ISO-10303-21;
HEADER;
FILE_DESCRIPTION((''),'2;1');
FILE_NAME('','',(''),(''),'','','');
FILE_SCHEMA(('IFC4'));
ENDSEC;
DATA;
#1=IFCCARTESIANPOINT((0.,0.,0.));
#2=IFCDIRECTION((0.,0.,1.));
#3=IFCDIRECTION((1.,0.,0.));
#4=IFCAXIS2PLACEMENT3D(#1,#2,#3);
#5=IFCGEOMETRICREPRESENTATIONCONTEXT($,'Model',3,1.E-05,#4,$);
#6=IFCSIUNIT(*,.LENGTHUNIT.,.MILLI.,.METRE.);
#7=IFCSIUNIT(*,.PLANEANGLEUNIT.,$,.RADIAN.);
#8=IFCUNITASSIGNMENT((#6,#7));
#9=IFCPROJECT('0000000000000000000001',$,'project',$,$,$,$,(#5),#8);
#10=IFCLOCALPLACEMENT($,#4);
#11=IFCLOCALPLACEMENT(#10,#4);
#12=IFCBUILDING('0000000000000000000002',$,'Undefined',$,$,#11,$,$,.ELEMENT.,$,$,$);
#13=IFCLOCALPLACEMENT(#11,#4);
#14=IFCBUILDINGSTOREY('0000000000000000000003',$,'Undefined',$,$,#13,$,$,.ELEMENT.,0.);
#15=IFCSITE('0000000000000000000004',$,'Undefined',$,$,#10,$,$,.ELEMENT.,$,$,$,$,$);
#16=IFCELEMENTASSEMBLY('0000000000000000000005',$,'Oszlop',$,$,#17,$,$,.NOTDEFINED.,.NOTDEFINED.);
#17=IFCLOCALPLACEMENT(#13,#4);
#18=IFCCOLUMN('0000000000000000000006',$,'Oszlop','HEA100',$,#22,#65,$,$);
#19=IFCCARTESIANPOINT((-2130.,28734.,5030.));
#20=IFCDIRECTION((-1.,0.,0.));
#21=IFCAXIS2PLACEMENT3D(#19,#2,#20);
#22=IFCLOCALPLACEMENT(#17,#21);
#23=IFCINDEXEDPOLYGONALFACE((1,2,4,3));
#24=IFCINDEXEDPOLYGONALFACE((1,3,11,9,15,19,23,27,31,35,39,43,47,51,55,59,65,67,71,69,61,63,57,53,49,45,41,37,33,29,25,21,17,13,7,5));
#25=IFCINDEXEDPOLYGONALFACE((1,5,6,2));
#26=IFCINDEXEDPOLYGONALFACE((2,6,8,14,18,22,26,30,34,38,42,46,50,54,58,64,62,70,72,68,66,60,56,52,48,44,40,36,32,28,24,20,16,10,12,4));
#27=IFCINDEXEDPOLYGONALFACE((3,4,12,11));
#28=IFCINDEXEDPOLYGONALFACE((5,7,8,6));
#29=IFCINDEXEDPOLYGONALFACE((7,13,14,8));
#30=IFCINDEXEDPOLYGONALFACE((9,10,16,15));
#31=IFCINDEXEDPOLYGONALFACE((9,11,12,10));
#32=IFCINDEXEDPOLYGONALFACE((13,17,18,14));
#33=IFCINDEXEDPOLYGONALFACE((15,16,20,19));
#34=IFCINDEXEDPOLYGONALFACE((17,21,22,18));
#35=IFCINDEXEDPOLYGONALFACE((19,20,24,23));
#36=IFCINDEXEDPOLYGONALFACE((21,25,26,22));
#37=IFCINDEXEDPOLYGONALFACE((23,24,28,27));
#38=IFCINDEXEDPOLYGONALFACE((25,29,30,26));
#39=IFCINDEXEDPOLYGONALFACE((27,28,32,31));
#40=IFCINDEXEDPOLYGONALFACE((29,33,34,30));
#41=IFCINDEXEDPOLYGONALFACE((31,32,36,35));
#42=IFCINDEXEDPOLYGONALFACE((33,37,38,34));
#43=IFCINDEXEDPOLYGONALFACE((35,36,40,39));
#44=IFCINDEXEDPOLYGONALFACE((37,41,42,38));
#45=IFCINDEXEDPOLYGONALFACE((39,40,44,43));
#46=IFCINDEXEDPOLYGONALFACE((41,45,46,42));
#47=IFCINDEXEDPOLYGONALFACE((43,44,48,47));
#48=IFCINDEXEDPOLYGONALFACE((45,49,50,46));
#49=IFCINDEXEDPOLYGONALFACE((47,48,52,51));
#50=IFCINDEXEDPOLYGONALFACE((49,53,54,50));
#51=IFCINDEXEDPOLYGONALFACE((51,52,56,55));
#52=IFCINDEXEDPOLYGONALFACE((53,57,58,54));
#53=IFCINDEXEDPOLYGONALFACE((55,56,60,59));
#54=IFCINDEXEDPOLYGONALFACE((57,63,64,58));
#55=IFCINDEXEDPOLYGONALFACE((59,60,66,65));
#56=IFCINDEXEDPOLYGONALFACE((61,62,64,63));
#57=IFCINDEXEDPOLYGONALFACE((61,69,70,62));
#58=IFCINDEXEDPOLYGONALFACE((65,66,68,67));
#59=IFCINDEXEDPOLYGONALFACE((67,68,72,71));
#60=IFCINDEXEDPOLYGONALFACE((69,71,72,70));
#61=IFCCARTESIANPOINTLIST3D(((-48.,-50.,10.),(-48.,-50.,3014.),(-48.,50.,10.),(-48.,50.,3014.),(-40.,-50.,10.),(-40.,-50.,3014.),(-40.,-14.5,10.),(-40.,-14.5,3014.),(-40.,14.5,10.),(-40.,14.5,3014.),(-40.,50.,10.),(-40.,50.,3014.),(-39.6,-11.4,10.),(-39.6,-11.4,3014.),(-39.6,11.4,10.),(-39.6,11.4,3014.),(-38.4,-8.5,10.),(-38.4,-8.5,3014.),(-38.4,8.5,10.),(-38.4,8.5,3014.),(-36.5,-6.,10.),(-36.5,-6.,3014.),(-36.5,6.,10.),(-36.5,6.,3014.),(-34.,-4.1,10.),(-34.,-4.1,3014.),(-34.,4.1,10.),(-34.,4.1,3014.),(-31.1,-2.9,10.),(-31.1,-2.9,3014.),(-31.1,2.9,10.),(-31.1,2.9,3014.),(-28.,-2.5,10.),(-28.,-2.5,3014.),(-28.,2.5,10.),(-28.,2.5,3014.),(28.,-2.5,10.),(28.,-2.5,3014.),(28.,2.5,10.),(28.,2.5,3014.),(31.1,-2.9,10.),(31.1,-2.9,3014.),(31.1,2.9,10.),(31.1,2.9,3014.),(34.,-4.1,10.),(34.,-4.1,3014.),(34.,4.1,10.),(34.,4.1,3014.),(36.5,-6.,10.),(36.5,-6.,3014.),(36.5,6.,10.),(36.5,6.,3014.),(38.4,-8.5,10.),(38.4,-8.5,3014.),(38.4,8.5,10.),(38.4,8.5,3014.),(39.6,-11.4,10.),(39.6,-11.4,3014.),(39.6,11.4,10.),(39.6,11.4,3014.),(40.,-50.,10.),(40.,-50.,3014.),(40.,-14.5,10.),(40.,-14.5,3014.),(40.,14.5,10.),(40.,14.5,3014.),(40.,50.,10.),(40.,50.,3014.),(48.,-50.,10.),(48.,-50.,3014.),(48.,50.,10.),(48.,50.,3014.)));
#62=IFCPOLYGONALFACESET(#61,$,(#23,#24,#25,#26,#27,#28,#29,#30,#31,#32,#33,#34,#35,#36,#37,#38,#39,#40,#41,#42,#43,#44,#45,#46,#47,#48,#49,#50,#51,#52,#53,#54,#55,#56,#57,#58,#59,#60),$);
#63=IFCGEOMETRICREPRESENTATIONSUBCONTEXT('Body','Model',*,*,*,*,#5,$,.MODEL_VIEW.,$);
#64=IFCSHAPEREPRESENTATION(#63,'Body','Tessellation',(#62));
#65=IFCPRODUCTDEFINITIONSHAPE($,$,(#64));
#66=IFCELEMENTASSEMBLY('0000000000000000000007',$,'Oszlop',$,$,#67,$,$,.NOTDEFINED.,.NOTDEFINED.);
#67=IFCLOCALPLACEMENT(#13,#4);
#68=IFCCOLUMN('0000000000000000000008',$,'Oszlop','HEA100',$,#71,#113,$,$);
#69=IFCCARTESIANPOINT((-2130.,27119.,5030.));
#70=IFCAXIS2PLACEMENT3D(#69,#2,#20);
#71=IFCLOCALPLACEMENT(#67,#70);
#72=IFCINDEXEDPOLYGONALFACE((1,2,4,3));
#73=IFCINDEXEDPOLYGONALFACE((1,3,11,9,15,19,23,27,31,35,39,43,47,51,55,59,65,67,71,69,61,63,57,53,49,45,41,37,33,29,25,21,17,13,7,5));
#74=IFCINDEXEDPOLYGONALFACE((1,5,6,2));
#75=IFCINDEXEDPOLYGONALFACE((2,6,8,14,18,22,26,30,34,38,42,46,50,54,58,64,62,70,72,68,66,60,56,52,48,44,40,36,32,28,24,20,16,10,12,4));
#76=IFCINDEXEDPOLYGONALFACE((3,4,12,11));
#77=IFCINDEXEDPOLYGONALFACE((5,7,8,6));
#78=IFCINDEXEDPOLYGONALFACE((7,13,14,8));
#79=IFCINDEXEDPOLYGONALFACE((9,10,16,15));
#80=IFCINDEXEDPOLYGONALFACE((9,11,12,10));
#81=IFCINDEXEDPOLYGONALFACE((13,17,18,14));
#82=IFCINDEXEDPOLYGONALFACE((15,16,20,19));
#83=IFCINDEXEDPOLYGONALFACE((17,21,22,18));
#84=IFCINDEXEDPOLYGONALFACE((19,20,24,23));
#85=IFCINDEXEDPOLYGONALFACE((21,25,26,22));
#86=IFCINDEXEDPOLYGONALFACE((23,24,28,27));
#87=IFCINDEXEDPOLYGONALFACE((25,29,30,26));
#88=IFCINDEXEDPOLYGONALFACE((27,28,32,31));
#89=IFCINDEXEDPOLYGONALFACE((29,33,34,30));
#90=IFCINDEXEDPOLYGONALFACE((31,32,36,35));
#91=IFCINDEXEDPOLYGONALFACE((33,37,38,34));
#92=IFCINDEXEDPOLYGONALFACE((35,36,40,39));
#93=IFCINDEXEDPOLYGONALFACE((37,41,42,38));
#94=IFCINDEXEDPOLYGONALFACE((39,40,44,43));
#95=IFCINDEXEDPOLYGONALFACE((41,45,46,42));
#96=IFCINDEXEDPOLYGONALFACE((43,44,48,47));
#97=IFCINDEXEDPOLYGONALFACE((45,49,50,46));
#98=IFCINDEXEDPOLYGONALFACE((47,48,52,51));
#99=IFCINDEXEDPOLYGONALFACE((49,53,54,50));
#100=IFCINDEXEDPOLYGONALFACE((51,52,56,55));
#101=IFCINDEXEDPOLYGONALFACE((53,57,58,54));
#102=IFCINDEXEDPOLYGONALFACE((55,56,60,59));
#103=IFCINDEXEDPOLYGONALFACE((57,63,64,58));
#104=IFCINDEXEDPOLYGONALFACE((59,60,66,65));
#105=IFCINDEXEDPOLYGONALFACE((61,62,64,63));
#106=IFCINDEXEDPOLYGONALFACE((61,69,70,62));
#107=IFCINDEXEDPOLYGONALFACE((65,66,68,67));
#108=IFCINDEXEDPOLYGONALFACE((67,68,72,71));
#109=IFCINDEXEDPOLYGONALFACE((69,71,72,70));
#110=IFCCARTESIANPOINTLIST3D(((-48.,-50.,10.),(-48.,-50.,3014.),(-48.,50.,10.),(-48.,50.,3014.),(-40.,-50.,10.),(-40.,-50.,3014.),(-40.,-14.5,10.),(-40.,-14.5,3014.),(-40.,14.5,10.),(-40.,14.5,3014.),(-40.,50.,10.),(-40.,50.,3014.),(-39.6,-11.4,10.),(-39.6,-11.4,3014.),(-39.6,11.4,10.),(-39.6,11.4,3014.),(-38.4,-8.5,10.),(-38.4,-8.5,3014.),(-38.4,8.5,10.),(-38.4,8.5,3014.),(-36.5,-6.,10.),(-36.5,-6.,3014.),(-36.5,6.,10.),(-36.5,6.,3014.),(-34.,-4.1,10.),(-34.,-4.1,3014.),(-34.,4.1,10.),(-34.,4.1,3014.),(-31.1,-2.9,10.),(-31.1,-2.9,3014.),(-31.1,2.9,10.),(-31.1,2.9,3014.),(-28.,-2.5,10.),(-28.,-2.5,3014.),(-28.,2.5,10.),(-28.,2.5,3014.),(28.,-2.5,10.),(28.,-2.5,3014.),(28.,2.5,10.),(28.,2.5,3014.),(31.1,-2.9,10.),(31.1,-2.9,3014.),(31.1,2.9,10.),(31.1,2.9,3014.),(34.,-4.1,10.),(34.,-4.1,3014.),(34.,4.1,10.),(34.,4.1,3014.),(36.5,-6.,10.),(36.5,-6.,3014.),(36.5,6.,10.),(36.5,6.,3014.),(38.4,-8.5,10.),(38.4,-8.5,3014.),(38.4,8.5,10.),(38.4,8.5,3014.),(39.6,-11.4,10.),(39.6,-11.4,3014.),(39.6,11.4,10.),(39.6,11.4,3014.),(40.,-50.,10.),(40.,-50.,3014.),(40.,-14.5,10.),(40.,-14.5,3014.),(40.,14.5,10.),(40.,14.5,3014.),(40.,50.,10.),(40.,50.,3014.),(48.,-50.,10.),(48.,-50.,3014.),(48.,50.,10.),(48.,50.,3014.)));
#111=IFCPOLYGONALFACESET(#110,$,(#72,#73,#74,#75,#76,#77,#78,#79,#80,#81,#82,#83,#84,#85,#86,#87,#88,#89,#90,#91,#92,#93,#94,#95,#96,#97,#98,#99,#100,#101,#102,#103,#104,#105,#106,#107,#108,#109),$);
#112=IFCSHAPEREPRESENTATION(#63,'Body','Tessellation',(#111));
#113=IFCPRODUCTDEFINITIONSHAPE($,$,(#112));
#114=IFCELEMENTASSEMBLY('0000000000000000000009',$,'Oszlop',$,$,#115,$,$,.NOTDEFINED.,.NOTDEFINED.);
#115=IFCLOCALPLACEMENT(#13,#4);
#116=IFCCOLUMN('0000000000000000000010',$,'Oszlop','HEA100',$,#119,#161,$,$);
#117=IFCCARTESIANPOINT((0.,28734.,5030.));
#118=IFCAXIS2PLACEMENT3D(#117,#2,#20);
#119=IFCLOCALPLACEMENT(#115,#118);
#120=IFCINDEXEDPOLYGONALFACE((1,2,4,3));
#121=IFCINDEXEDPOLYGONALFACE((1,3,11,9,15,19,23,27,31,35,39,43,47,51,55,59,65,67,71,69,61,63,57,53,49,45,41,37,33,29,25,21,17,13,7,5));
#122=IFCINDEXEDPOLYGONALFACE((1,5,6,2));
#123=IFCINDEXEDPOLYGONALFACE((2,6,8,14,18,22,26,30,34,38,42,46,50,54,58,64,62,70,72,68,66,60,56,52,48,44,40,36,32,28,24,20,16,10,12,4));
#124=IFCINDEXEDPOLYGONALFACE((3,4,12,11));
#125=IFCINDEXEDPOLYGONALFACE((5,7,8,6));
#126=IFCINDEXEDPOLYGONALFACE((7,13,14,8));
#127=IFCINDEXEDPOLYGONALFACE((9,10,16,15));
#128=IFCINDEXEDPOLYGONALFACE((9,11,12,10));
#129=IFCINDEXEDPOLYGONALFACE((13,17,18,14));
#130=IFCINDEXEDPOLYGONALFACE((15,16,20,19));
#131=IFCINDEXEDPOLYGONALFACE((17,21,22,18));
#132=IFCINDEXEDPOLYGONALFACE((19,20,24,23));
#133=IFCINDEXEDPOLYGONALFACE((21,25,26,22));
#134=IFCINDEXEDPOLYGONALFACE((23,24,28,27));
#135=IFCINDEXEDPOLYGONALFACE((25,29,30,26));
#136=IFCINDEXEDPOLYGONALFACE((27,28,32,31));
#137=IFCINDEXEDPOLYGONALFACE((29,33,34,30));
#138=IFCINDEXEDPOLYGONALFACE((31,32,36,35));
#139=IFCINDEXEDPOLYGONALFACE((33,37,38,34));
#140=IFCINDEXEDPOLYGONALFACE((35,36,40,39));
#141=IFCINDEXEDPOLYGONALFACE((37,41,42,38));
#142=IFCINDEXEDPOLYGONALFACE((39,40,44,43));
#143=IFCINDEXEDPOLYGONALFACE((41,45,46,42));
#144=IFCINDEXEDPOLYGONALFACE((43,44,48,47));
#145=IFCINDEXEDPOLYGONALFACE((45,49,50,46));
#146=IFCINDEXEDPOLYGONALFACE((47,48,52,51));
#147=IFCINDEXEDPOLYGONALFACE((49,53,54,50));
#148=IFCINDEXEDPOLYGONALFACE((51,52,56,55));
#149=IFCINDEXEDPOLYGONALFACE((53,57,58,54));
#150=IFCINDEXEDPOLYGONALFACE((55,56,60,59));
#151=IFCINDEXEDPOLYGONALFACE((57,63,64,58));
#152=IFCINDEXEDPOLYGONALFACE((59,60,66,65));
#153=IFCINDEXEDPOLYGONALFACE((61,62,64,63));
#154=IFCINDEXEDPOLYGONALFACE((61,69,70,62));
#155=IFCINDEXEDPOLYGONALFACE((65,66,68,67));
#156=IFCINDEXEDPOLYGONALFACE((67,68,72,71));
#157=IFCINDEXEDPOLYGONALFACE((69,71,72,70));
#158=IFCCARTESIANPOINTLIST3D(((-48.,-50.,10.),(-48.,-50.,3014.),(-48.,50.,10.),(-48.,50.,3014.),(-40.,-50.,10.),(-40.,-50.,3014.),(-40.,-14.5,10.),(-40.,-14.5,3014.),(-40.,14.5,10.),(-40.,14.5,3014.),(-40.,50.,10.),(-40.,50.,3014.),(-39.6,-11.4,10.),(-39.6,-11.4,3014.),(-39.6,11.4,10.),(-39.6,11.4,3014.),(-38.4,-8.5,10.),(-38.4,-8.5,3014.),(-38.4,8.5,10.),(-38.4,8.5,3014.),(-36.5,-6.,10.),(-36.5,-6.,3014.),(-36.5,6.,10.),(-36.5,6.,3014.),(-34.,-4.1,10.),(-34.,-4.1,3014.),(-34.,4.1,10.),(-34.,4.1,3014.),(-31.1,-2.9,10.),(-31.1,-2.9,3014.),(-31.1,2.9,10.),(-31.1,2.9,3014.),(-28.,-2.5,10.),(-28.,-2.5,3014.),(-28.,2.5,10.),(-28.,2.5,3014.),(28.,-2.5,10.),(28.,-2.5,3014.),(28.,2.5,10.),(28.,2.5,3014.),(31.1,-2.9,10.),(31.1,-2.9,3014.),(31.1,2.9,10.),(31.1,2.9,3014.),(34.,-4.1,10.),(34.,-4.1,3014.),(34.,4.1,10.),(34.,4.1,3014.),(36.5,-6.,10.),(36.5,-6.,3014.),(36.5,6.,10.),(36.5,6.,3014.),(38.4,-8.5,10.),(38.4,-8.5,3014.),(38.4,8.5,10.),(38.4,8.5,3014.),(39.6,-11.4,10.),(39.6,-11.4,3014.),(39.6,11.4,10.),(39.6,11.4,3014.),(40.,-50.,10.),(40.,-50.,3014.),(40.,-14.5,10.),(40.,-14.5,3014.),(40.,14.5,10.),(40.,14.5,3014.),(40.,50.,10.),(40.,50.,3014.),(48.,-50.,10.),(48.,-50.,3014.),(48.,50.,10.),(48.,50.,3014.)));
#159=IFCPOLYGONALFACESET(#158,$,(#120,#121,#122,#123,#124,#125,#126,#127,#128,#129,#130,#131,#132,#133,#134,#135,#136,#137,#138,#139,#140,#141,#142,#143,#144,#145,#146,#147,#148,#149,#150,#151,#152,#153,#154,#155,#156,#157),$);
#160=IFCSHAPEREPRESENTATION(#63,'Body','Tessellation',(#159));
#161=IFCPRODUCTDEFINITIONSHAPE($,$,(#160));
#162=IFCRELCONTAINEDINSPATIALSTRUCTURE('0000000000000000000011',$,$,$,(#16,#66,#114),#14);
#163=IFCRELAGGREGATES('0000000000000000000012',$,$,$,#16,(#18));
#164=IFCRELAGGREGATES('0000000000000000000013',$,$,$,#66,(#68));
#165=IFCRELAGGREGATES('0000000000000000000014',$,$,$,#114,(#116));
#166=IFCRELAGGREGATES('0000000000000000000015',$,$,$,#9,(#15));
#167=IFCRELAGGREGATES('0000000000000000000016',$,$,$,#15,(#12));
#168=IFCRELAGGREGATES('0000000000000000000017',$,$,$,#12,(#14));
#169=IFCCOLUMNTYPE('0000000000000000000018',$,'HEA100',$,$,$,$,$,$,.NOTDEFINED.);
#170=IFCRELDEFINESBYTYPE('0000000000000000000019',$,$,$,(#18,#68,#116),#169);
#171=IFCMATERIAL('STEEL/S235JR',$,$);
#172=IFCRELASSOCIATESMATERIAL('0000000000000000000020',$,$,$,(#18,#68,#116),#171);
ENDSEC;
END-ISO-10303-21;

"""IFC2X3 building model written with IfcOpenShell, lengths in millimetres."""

from ifc_helpers import new_model, si_unit, frame, origin_with_axes, origin_2d_with_axis, place, context, subcontext, project, spatial, i_section, extrude, clip, halfspace, material, type_object, element, aggregate, save


model = new_model("IFC2X3")

# Units and contexts
model_context = context("Model", 3, precision=1e-05, world=origin_with_axes())
body_context = subcontext(model_context, "Body", "Model", "MODEL_VIEW")
ifc_project = project(units=[si_unit("LENGTHUNIT", "METRE", prefix="MILLI"), si_unit("PLANEANGLEUNIT", "RADIAN")], contexts=[model_context])

# Site, building, storey
site_placement = place(None, origin_with_axes())
site = spatial("IfcSite", under=ifc_project, at=site_placement, Name="Undefined", CompositionType="ELEMENT")
building_placement = place(site_placement, origin_with_axes())
building = spatial("IfcBuilding", under=site, at=building_placement, Name="Undefined", CompositionType="ELEMENT")
storey_placement = place(building_placement, origin_with_axes())
storey = spatial("IfcBuildingStorey", under=building, at=storey_placement, Name="Undefined", CompositionType="ELEMENT", Elevation=0.0)

# Element assemblies, columns
assembly_1_placement = place(storey_placement, origin_with_axes())
assembly_1 = element("IfcElementAssembly", 1, at=assembly_1_placement, inside=storey, Name="Oszlop", AssemblyPlace="NOTDEFINED", PredefinedType="NOTDEFINED")
ifc_material_1 = material(Name="STEEL/S235JR")
column_type = type_object("IfcColumnType", Name="HEA100", PredefinedType="NOTDEFINED")
column_1_placement = place(assembly_1_placement, frame((-2130.0, 28734.0, 5030.0), z_axis=(0.0, 0.0, 1.0), x_axis=(-1.0, 0.0, 0.0)))
column_1 = element("IfcColumn", 2, at=column_1_placement, type_object=column_type, material=ifc_material_1, Name="Oszlop", Description="HEA100", context=body_context, shape_type="Clipping", body=[
    clip(clip(extrude(i_section(OverallWidth=100.0, OverallDepth=96.0, WebThickness=5.0, FlangeThickness=8.0, FilletRadius=12.0, at=origin_2d_with_axis()), frame((0.0, 0.0, 3024.0), z_axis=(0.0, 0.0, -1.0), x_axis=(0.0, 1.0, 0.0)), (0.0, 0.0, 1.0), 3024.0), halfspace(frame((-48.0, 0.0, 3014.0), z_axis=(0.0, 0.0, -1.0), x_axis=(0.0, -1.0, 0.0)), True)), halfspace(frame((-48.0, 0.0, 10.0), z_axis=(0.0, 0.0, 1.0), x_axis=(0.0, 1.0, 0.0)), True)),
])
assembly_2_placement = place(storey_placement, origin_with_axes())
assembly_2 = element("IfcElementAssembly", 3, at=assembly_2_placement, inside=storey, Name="Oszlop", AssemblyPlace="NOTDEFINED", PredefinedType="NOTDEFINED")
column_2_placement = place(assembly_2_placement, frame((-2130.0, 27119.0, 5030.0), z_axis=(0.0, 0.0, 1.0), x_axis=(-1.0, 0.0, 0.0)))
column_2 = element("IfcColumn", 4, at=column_2_placement, type_object=column_type, material=ifc_material_1, Name="Oszlop", Description="HEA100", context=body_context, shape_type="Clipping", body=[
    clip(clip(extrude(i_section(OverallWidth=100.0, OverallDepth=96.0, WebThickness=5.0, FlangeThickness=8.0, FilletRadius=12.0, at=origin_2d_with_axis()), frame((0.0, 0.0, 3024.0), z_axis=(0.0, 0.0, -1.0), x_axis=(0.0, 1.0, 0.0)), (0.0, 0.0, 1.0), 3024.0), halfspace(frame((-48.0, 0.0, 3014.0), z_axis=(0.0, 0.0, -1.0), x_axis=(0.0, -1.0, 0.0)), True)), halfspace(frame((-48.0, 0.0, 10.0), z_axis=(0.0, 0.0, 1.0), x_axis=(0.0, 1.0, 0.0)), True)),
])
assembly_3_placement = place(storey_placement, origin_with_axes())
assembly_3 = element("IfcElementAssembly", 5, at=assembly_3_placement, inside=storey, Name="Oszlop", AssemblyPlace="NOTDEFINED", PredefinedType="NOTDEFINED")
column_3_placement = place(assembly_3_placement, frame((0.0, 28734.0, 5030.0), z_axis=(0.0, 0.0, 1.0), x_axis=(-1.0, 0.0, 0.0)))
column_3 = element("IfcColumn", 6, at=column_3_placement, type_object=column_type, material=ifc_material_1, Name="Oszlop", Description="HEA100", context=body_context, shape_type="Clipping", body=[
    clip(clip(extrude(i_section(OverallWidth=100.0, OverallDepth=96.0, WebThickness=5.0, FlangeThickness=8.0, FilletRadius=12.0, at=origin_2d_with_axis()), frame((0.0, 0.0, 3024.0), z_axis=(0.0, 0.0, -1.0), x_axis=(0.0, 1.0, 0.0)), (0.0, 0.0, 1.0), 3024.0), halfspace(frame((-48.0, 0.0, 3014.0), z_axis=(0.0, 0.0, -1.0), x_axis=(0.0, -1.0, 0.0)), True)), halfspace(frame((-48.0, 0.0, 10.0), z_axis=(0.0, 0.0, 1.0), x_axis=(0.0, 1.0, 0.0)), True)),
])

aggregate(assembly_1, [column_1])
aggregate(assembly_2, [column_2])
aggregate(assembly_3, [column_3])

save(model, "model.ifc")
